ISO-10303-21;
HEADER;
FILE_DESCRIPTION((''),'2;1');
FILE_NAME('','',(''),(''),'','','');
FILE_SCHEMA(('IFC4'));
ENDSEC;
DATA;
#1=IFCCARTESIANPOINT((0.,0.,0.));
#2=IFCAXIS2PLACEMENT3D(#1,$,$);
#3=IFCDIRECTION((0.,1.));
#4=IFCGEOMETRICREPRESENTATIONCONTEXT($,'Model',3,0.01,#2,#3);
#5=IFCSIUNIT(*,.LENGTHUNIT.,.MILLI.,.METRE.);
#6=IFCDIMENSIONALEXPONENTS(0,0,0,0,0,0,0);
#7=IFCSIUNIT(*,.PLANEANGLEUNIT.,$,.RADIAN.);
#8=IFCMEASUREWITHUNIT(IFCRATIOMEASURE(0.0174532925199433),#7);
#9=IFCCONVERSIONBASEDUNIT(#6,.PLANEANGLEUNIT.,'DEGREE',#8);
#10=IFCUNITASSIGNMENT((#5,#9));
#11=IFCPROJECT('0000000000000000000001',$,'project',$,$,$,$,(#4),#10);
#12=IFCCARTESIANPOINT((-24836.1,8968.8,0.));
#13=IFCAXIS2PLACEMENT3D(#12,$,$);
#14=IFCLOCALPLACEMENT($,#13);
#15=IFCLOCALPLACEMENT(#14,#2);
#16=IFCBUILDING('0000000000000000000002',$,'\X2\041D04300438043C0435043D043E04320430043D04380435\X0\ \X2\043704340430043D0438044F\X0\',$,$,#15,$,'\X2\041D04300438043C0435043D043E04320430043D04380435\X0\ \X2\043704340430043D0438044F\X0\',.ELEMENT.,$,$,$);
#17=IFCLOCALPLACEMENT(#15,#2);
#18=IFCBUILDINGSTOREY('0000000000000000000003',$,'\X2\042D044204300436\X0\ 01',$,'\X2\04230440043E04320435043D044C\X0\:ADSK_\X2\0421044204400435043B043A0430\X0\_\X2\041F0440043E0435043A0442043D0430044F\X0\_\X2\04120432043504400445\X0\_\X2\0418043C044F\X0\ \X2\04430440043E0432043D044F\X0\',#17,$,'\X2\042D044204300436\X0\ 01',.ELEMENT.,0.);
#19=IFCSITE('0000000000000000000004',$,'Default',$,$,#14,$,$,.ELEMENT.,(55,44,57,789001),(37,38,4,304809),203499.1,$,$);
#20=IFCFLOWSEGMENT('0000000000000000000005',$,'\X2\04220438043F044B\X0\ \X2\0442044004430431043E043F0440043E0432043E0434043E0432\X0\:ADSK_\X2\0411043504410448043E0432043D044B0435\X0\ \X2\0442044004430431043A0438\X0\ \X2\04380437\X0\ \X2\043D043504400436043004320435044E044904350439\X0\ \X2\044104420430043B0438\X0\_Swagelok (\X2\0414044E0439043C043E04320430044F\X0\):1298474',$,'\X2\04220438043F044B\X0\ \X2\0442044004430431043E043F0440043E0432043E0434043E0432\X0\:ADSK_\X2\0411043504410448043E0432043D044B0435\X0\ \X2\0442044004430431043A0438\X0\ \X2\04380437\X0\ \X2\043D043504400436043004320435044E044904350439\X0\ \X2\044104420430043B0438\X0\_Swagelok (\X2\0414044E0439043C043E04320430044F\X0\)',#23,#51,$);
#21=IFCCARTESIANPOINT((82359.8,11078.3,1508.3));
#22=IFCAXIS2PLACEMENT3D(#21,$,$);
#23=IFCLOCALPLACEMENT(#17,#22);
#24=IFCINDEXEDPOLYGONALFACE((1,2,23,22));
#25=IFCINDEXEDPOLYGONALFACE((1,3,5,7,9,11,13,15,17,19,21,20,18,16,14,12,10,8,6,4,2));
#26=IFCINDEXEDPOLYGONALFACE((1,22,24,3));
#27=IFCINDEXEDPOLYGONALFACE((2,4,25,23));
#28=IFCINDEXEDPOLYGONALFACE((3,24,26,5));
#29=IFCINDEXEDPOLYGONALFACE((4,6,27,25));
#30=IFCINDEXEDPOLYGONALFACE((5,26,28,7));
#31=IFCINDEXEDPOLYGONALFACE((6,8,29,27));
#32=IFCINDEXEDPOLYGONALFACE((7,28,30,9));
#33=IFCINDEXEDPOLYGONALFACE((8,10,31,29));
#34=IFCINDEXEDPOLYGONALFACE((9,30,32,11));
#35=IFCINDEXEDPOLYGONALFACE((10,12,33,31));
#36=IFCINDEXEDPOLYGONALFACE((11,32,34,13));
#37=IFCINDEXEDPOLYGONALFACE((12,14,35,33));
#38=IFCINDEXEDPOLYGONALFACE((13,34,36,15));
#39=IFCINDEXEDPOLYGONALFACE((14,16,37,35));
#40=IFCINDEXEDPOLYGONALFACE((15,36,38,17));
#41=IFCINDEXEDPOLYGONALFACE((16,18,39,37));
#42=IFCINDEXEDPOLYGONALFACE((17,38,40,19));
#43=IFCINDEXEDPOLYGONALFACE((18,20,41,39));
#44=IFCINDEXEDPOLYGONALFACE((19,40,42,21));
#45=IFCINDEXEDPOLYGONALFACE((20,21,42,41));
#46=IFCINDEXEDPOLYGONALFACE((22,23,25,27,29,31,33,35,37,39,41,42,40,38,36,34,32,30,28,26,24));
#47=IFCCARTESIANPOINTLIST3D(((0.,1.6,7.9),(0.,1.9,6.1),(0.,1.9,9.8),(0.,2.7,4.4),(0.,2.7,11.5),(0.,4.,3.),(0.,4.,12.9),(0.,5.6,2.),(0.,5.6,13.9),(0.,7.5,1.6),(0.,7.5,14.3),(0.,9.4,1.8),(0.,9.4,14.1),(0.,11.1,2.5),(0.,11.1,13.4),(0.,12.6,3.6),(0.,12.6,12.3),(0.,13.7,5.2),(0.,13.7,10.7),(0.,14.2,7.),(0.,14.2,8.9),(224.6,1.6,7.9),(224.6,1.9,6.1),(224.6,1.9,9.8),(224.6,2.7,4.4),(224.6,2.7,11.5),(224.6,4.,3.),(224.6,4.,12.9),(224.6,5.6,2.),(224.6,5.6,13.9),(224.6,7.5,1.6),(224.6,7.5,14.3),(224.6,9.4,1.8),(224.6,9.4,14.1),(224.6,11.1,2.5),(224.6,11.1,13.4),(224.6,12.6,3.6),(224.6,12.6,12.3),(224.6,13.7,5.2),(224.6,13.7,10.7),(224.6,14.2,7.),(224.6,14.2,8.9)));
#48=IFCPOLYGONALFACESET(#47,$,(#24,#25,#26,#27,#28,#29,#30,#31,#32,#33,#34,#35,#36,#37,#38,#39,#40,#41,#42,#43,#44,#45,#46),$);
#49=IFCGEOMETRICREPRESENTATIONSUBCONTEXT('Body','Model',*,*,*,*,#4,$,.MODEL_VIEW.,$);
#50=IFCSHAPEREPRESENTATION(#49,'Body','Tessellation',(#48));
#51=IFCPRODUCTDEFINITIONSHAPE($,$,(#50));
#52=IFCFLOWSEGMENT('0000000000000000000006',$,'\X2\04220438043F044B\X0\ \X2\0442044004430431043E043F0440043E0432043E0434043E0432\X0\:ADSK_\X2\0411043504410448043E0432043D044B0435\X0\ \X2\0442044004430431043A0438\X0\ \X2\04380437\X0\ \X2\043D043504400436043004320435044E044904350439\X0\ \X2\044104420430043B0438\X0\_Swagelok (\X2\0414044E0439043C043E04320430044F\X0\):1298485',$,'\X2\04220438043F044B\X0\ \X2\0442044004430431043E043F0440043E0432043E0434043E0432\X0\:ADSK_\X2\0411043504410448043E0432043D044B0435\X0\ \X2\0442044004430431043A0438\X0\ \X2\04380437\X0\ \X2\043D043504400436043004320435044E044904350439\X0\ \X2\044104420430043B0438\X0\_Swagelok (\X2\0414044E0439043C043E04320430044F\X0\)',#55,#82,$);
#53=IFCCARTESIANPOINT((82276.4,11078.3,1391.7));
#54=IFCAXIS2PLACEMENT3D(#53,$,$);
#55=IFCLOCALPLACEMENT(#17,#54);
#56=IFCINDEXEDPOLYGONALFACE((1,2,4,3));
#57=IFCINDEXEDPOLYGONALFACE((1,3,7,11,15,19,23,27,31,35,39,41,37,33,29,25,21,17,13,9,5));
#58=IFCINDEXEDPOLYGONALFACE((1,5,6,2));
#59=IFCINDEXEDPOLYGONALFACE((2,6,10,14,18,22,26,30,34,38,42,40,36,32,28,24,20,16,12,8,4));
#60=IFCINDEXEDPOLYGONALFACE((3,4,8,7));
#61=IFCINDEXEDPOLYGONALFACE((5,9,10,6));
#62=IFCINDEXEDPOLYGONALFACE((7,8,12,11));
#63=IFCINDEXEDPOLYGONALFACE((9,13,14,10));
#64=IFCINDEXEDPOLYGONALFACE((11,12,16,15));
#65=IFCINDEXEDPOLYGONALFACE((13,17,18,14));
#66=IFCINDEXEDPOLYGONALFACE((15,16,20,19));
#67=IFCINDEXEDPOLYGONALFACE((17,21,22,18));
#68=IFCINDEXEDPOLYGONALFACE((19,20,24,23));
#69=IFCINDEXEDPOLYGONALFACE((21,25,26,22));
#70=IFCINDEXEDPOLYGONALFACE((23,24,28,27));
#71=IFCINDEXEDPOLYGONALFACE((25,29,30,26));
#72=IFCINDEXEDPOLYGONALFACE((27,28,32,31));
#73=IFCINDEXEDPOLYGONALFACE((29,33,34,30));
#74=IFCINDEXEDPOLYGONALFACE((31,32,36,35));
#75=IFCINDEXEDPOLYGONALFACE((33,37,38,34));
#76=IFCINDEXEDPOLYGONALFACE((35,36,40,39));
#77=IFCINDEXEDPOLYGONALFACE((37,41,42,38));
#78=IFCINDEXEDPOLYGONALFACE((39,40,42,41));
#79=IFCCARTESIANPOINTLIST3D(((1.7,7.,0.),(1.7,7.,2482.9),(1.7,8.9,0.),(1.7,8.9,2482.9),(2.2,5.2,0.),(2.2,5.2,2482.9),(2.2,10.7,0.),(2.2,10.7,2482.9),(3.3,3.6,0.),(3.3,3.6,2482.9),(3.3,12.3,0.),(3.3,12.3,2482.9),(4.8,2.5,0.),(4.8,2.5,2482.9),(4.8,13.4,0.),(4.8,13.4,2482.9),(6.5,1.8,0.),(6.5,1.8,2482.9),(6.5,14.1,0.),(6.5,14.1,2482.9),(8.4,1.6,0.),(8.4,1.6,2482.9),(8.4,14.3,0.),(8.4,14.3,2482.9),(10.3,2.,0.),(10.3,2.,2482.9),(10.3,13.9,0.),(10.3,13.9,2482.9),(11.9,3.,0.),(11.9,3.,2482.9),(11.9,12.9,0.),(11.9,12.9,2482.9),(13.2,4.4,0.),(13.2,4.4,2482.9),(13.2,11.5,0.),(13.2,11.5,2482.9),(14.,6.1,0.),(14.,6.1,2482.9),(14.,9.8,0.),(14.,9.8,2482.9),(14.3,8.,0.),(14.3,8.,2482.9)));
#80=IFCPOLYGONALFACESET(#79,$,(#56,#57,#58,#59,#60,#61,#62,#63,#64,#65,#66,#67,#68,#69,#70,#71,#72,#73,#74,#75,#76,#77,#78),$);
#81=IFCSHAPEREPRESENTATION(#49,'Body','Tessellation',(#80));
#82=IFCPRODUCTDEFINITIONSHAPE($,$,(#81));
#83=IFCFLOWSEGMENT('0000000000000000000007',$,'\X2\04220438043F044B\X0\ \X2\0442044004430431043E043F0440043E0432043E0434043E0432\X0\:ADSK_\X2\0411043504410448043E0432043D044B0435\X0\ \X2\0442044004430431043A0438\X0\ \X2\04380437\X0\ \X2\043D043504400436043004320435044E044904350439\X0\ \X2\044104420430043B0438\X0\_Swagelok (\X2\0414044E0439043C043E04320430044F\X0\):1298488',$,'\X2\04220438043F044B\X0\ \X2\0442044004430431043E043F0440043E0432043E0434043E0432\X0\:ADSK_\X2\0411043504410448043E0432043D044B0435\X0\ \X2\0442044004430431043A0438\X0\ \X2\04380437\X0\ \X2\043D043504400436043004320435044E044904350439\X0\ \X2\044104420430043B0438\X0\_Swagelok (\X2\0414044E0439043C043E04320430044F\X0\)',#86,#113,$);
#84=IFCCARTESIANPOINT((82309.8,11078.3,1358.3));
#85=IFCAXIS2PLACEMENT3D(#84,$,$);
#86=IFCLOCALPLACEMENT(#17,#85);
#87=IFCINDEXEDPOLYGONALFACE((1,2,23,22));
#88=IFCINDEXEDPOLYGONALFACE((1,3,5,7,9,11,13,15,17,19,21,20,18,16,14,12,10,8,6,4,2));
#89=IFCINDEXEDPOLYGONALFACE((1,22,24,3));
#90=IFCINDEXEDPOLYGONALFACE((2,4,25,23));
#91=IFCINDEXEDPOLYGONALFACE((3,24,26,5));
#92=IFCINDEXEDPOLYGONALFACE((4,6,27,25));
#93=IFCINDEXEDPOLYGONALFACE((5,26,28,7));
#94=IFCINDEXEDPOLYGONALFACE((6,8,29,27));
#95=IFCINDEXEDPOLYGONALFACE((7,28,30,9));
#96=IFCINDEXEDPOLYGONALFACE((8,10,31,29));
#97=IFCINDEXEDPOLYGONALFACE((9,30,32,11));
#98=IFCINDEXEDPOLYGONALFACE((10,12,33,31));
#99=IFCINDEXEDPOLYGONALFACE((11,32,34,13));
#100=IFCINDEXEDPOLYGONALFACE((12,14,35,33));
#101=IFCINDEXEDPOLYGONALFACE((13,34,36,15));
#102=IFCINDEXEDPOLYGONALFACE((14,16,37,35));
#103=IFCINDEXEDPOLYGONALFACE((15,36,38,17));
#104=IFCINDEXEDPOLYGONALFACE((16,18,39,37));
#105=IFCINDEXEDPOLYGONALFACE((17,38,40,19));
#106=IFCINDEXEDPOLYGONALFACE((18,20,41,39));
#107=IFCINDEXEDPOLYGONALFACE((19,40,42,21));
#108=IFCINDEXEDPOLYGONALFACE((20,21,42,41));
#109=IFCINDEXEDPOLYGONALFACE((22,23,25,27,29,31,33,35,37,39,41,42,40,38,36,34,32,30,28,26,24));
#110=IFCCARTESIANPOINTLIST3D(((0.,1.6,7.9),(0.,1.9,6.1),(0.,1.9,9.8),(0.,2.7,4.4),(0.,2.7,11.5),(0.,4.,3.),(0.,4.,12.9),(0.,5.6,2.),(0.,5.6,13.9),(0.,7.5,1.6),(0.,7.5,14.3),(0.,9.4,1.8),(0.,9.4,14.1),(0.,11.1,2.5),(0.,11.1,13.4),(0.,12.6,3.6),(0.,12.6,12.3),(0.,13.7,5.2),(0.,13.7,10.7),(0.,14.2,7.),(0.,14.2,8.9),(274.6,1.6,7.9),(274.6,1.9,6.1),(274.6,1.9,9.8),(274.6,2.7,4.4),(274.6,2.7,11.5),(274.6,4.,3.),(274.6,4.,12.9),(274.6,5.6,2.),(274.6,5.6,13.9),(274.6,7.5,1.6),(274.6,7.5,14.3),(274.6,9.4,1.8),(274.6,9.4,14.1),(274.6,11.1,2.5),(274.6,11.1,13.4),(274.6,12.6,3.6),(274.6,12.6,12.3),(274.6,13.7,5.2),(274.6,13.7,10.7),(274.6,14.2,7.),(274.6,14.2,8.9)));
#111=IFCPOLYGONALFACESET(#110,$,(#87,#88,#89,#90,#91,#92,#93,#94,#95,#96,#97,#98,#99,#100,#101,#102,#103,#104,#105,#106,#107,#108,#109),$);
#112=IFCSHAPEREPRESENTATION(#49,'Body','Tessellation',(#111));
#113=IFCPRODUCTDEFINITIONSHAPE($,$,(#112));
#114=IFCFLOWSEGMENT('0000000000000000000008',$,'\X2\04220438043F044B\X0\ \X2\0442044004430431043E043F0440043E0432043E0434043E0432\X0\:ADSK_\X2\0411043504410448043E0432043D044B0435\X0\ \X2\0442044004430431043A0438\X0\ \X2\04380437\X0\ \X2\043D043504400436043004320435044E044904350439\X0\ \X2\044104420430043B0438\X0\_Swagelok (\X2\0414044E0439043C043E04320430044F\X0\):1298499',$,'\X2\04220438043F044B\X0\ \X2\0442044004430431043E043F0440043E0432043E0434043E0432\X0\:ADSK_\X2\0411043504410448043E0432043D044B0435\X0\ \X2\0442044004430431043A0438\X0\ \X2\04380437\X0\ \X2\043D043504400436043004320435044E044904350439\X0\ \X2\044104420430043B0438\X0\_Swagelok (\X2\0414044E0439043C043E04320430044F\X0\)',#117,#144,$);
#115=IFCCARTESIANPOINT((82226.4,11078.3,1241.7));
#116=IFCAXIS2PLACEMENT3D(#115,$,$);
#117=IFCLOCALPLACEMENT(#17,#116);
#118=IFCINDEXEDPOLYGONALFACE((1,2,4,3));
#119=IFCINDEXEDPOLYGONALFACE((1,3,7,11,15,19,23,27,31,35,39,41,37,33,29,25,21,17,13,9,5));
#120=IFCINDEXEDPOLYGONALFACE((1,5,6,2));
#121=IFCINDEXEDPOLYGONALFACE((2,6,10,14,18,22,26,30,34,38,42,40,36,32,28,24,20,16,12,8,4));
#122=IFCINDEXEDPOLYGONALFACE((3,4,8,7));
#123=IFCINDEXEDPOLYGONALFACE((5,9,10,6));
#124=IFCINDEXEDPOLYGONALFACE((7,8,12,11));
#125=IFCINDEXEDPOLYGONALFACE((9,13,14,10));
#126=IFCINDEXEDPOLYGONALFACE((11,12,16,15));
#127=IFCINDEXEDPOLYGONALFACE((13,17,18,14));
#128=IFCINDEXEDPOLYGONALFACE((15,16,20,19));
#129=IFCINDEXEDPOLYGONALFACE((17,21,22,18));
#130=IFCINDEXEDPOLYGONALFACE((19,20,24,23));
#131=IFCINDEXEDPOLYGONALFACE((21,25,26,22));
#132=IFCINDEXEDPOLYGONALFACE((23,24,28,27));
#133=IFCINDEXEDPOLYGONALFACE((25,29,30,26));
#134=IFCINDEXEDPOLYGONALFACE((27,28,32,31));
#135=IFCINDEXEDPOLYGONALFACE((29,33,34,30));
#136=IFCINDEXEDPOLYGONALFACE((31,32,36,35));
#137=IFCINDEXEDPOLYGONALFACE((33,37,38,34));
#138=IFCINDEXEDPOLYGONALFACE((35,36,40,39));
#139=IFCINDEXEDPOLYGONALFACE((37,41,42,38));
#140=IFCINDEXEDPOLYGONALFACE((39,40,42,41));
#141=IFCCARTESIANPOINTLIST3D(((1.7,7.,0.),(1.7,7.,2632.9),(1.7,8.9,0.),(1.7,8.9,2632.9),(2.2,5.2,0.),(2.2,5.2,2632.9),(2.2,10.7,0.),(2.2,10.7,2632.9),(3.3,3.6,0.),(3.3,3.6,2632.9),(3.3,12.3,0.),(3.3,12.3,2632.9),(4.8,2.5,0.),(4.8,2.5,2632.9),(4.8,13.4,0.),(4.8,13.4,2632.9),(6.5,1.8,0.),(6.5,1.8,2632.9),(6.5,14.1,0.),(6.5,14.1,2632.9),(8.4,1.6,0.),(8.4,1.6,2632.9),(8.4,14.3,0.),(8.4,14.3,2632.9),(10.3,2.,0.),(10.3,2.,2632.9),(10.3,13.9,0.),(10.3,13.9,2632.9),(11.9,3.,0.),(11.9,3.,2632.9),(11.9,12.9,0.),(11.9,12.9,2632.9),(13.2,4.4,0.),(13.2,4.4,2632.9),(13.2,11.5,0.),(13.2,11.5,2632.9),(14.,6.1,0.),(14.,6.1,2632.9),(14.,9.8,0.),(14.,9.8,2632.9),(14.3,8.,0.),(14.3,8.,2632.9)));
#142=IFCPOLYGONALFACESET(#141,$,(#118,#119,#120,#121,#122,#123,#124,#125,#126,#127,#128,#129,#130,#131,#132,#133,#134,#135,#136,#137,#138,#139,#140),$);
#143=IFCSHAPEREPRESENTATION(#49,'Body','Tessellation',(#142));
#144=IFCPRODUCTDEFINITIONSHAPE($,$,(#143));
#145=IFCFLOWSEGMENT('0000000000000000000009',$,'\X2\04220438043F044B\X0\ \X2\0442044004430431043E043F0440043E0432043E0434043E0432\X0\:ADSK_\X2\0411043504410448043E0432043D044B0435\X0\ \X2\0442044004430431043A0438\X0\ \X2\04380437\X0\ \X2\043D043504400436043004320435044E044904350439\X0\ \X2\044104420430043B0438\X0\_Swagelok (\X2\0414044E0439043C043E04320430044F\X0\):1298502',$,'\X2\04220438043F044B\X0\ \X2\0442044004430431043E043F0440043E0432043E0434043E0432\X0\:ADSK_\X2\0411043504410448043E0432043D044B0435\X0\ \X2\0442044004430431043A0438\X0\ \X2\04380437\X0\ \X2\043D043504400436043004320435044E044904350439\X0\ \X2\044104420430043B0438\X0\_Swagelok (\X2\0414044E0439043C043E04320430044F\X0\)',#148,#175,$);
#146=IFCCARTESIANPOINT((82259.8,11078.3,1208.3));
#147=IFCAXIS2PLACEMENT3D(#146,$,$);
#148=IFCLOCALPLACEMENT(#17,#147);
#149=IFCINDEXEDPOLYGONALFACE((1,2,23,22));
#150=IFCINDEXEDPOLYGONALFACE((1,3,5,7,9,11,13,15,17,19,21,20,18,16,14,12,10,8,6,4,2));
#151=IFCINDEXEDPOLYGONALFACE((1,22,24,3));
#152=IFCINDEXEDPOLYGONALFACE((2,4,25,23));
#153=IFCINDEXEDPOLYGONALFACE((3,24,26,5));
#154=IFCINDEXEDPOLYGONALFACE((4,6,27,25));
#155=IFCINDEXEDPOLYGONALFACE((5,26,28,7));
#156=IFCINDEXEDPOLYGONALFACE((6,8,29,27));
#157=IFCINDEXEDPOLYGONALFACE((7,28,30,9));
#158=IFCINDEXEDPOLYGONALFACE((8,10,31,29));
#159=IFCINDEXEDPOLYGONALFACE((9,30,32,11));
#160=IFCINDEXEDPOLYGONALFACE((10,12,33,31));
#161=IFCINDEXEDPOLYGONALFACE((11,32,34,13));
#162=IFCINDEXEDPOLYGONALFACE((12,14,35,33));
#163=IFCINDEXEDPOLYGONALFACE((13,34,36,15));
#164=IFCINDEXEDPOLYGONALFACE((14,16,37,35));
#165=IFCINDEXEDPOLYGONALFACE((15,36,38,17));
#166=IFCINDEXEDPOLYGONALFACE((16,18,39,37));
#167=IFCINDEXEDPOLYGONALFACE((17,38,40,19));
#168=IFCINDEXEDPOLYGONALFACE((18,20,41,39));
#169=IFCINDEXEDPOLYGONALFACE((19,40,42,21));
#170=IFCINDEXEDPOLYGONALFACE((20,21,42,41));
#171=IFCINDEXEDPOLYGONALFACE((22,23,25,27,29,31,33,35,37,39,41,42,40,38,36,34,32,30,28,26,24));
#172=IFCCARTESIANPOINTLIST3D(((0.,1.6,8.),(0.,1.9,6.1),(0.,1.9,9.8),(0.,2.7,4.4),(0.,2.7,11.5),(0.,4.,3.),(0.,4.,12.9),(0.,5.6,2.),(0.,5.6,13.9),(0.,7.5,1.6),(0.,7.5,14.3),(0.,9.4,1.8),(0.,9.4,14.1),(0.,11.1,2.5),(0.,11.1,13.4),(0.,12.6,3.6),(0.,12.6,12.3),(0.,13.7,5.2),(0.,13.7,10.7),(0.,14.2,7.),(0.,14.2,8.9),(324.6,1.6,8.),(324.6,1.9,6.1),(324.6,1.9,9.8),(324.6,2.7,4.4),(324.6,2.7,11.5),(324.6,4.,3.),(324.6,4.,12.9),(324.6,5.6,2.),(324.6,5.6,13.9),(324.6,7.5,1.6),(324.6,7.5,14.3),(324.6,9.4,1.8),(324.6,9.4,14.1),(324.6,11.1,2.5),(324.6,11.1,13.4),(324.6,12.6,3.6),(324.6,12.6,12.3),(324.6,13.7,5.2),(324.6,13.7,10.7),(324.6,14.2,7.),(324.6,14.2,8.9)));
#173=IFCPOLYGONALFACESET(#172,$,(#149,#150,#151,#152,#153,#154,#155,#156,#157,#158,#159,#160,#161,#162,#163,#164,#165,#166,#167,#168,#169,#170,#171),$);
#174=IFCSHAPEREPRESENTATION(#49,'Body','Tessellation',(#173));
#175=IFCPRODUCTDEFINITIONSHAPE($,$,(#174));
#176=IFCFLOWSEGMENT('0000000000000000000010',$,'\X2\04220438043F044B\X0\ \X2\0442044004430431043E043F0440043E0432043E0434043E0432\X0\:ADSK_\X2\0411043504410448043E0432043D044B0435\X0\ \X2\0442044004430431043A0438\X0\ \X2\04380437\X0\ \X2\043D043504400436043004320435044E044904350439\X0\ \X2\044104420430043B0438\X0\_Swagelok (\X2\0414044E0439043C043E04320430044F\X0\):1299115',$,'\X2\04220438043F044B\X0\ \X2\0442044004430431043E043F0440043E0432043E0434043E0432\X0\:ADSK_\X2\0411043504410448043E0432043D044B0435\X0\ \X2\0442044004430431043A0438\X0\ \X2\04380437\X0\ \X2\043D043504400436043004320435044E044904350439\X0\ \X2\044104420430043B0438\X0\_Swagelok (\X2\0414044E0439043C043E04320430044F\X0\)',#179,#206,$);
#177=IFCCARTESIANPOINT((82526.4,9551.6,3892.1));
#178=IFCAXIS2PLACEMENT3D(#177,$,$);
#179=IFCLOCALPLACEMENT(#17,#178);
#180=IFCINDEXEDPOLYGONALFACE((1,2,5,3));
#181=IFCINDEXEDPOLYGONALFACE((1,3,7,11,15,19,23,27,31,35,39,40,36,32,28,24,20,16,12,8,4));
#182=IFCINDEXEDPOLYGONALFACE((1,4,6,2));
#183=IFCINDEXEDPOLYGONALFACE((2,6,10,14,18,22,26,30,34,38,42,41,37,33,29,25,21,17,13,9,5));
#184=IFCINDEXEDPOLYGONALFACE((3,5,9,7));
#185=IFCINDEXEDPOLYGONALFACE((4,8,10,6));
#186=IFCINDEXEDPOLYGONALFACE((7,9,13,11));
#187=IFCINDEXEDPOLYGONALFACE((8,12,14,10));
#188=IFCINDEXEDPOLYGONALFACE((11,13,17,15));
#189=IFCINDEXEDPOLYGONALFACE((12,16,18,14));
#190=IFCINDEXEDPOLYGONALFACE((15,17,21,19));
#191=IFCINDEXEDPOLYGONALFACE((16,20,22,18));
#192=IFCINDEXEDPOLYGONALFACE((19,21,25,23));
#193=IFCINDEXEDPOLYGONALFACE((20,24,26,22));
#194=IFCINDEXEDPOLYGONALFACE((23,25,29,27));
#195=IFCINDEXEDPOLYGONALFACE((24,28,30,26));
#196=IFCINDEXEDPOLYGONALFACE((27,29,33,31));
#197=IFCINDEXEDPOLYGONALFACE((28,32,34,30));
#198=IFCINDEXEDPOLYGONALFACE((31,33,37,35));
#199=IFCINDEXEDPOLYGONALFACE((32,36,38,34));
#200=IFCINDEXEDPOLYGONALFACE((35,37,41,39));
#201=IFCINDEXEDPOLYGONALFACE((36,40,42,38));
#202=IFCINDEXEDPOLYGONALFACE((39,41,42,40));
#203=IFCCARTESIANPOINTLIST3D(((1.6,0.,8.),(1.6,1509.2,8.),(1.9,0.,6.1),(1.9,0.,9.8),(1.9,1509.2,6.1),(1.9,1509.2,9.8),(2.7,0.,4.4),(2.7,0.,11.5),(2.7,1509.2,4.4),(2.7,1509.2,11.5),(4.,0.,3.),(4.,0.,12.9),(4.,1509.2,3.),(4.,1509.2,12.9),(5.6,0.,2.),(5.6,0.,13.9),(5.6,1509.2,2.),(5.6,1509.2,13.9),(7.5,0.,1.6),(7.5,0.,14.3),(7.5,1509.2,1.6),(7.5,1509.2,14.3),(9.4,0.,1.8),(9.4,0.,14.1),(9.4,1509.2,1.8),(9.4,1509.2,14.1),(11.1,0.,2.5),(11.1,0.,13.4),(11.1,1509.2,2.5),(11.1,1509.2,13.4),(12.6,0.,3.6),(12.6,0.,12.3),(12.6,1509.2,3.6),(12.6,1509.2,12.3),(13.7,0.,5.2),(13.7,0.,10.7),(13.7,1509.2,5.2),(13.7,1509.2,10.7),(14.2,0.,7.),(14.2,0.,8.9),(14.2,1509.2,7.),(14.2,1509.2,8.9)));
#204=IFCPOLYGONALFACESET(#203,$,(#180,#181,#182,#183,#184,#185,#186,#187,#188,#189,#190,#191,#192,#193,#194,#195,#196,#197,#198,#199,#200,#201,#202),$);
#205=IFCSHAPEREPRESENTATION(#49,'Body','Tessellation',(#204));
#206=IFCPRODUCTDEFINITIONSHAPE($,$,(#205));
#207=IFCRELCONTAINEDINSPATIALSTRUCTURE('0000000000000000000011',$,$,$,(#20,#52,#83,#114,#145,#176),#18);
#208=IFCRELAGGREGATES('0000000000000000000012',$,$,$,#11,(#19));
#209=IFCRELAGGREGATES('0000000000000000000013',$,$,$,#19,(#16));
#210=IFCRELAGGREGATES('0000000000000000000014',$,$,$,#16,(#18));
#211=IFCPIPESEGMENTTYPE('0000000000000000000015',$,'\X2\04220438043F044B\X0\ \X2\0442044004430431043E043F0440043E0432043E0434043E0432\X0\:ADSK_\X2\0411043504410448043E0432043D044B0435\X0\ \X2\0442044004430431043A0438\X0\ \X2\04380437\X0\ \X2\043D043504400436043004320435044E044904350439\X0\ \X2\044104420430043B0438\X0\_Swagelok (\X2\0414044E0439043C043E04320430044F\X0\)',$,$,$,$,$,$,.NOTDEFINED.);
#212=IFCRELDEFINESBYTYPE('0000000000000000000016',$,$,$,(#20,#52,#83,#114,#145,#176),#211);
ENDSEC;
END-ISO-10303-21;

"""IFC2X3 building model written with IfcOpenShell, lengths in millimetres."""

from ifc_helpers import new_model, entity, si_unit, converted_unit, direction, frame, origin, origin_2d_with_axis, place, context, subcontext, project, spatial, circle, extrude, type_object, element, save


model = new_model("IFC2X3")

# Units and contexts
model_context = context("Model", 3, precision=0.01, world=origin(), true_north=direction((0.0, 1.0)))
body_context = subcontext(model_context, "Body", "Model", "MODEL_VIEW")
ifc_project = project(units=[si_unit("LENGTHUNIT", "METRE", prefix="MILLI"), converted_unit("PLANEANGLEUNIT", "DEGREE", entity("IfcRatioMeasure", 0.0174532925199433), si_unit("PLANEANGLEUNIT", "RADIAN"), dimensions=[0, 0, 0, 0, 0, 0, 0])], contexts=[model_context])

# Site, building, storey
site_placement = place(None, frame((-24836.1, 8968.8, 0.0)))
site = spatial("IfcSite", under=ifc_project, at=site_placement, Name="Default", CompositionType="ELEMENT", RefLatitude=(55, 44, 57, 789001), RefLongitude=(37, 38, 4, 304809), RefElevation=203499.1)
building_placement = place(site_placement, origin())
building = spatial("IfcBuilding", under=site, at=building_placement, Name="Наименование здания", LongName="Наименование здания", CompositionType="ELEMENT")
storey_placement = place(building_placement, origin())
storey = spatial("IfcBuildingStorey", under=building, at=storey_placement, Name="Этаж 01", ObjectType="Уровень:ADSK_Стрелка_Проектная_Вверх_Имя уровня", LongName="Этаж 01", CompositionType="ELEMENT", Elevation=0.0)

# Flow segments
pipe_segment_type = type_object("IfcPipeSegmentType", Name="Типы трубопроводов:ADSK_Бесшовные трубки из нержавеющей стали_Swagelok (Дюймовая)", PredefinedType="NOTDEFINED")
flow_segment_1_placement = place(storey_placement, frame((82359.8, 11078.3, 1508.3)))
element("IfcFlowSegment", 1, at=flow_segment_1_placement, inside=storey, type_object=pipe_segment_type, Name="Типы трубопроводов:ADSK_Бесшовные трубки из нержавеющей стали_Swagelok (Дюймовая):1298474", ObjectType="Типы трубопроводов:ADSK_Бесшовные трубки из нержавеющей стали_Swagelok (Дюймовая)", context=body_context, shape_type="SweptSolid", body=[
    extrude(circle(Radius=6.3, at=origin_2d_with_axis()), frame((0.0, 8.0, 8.0), z_axis=(1.0, 0.0, 0.0), x_axis=(0.0, -1.0, 0.0)), (0.0, 0.0, 1.0), 224.6),
])
flow_segment_2_placement = place(storey_placement, frame((82276.4, 11078.3, 1391.7)))
element("IfcFlowSegment", 2, at=flow_segment_2_placement, inside=storey, type_object=pipe_segment_type, Name="Типы трубопроводов:ADSK_Бесшовные трубки из нержавеющей стали_Swagelok (Дюймовая):1298485", ObjectType="Типы трубопроводов:ADSK_Бесшовные трубки из нержавеющей стали_Swagelok (Дюймовая)", context=body_context, shape_type="SweptSolid", body=[
    extrude(circle(Radius=6.3, at=origin_2d_with_axis()), frame((8.0, 8.0, 0.0)), (0.0, 0.0, 1.0), 2482.9),
])
flow_segment_3_placement = place(storey_placement, frame((82309.8, 11078.3, 1358.3)))
element("IfcFlowSegment", 3, at=flow_segment_3_placement, inside=storey, type_object=pipe_segment_type, Name="Типы трубопроводов:ADSK_Бесшовные трубки из нержавеющей стали_Swagelok (Дюймовая):1298488", ObjectType="Типы трубопроводов:ADSK_Бесшовные трубки из нержавеющей стали_Swagelok (Дюймовая)", context=body_context, shape_type="SweptSolid", body=[
    extrude(circle(Radius=6.3, at=origin_2d_with_axis()), frame((0.0, 8.0, 8.0), z_axis=(1.0, 0.0, 0.0), x_axis=(0.0, -1.0, 0.0)), (0.0, 0.0, 1.0), 274.6),
])
flow_segment_4_placement = place(storey_placement, frame((82226.4, 11078.3, 1241.7)))
element("IfcFlowSegment", 4, at=flow_segment_4_placement, inside=storey, type_object=pipe_segment_type, Name="Типы трубопроводов:ADSK_Бесшовные трубки из нержавеющей стали_Swagelok (Дюймовая):1298499", ObjectType="Типы трубопроводов:ADSK_Бесшовные трубки из нержавеющей стали_Swagelok (Дюймовая)", context=body_context, shape_type="SweptSolid", body=[
    extrude(circle(Radius=6.3, at=origin_2d_with_axis()), frame((8.0, 8.0, 0.0)), (0.0, 0.0, 1.0), 2632.9),
])
flow_segment_5_placement = place(storey_placement, frame((82259.8, 11078.3, 1208.3)))
element("IfcFlowSegment", 5, at=flow_segment_5_placement, inside=storey, type_object=pipe_segment_type, Name="Типы трубопроводов:ADSK_Бесшовные трубки из нержавеющей стали_Swagelok (Дюймовая):1298502", ObjectType="Типы трубопроводов:ADSK_Бесшовные трубки из нержавеющей стали_Swagelok (Дюймовая)", context=body_context, shape_type="SweptSolid", body=[
    extrude(circle(Radius=6.3, at=origin_2d_with_axis()), frame((0.0, 8.0, 8.0), z_axis=(1.0, 0.0, 0.0), x_axis=(0.0, -1.0, 0.0)), (0.0, 0.0, 1.0), 324.6),
])
flow_segment_6_placement = place(storey_placement, frame((82526.4, 9551.6, 3892.1)))
element("IfcFlowSegment", 6, at=flow_segment_6_placement, inside=storey, type_object=pipe_segment_type, Name="Типы трубопроводов:ADSK_Бесшовные трубки из нержавеющей стали_Swagelok (Дюймовая):1299115", ObjectType="Типы трубопроводов:ADSK_Бесшовные трубки из нержавеющей стали_Swagelok (Дюймовая)", context=body_context, shape_type="SweptSolid", body=[
    extrude(circle(Radius=6.3, at=origin_2d_with_axis()), frame((8.0, 0.0, 8.0), z_axis=(0.0, 1.0, 0.0), x_axis=(-1.0, 0.0, 0.0)), (0.0, 0.0, 1.0), 1509.2),
])

save(model, "model.ifc")
